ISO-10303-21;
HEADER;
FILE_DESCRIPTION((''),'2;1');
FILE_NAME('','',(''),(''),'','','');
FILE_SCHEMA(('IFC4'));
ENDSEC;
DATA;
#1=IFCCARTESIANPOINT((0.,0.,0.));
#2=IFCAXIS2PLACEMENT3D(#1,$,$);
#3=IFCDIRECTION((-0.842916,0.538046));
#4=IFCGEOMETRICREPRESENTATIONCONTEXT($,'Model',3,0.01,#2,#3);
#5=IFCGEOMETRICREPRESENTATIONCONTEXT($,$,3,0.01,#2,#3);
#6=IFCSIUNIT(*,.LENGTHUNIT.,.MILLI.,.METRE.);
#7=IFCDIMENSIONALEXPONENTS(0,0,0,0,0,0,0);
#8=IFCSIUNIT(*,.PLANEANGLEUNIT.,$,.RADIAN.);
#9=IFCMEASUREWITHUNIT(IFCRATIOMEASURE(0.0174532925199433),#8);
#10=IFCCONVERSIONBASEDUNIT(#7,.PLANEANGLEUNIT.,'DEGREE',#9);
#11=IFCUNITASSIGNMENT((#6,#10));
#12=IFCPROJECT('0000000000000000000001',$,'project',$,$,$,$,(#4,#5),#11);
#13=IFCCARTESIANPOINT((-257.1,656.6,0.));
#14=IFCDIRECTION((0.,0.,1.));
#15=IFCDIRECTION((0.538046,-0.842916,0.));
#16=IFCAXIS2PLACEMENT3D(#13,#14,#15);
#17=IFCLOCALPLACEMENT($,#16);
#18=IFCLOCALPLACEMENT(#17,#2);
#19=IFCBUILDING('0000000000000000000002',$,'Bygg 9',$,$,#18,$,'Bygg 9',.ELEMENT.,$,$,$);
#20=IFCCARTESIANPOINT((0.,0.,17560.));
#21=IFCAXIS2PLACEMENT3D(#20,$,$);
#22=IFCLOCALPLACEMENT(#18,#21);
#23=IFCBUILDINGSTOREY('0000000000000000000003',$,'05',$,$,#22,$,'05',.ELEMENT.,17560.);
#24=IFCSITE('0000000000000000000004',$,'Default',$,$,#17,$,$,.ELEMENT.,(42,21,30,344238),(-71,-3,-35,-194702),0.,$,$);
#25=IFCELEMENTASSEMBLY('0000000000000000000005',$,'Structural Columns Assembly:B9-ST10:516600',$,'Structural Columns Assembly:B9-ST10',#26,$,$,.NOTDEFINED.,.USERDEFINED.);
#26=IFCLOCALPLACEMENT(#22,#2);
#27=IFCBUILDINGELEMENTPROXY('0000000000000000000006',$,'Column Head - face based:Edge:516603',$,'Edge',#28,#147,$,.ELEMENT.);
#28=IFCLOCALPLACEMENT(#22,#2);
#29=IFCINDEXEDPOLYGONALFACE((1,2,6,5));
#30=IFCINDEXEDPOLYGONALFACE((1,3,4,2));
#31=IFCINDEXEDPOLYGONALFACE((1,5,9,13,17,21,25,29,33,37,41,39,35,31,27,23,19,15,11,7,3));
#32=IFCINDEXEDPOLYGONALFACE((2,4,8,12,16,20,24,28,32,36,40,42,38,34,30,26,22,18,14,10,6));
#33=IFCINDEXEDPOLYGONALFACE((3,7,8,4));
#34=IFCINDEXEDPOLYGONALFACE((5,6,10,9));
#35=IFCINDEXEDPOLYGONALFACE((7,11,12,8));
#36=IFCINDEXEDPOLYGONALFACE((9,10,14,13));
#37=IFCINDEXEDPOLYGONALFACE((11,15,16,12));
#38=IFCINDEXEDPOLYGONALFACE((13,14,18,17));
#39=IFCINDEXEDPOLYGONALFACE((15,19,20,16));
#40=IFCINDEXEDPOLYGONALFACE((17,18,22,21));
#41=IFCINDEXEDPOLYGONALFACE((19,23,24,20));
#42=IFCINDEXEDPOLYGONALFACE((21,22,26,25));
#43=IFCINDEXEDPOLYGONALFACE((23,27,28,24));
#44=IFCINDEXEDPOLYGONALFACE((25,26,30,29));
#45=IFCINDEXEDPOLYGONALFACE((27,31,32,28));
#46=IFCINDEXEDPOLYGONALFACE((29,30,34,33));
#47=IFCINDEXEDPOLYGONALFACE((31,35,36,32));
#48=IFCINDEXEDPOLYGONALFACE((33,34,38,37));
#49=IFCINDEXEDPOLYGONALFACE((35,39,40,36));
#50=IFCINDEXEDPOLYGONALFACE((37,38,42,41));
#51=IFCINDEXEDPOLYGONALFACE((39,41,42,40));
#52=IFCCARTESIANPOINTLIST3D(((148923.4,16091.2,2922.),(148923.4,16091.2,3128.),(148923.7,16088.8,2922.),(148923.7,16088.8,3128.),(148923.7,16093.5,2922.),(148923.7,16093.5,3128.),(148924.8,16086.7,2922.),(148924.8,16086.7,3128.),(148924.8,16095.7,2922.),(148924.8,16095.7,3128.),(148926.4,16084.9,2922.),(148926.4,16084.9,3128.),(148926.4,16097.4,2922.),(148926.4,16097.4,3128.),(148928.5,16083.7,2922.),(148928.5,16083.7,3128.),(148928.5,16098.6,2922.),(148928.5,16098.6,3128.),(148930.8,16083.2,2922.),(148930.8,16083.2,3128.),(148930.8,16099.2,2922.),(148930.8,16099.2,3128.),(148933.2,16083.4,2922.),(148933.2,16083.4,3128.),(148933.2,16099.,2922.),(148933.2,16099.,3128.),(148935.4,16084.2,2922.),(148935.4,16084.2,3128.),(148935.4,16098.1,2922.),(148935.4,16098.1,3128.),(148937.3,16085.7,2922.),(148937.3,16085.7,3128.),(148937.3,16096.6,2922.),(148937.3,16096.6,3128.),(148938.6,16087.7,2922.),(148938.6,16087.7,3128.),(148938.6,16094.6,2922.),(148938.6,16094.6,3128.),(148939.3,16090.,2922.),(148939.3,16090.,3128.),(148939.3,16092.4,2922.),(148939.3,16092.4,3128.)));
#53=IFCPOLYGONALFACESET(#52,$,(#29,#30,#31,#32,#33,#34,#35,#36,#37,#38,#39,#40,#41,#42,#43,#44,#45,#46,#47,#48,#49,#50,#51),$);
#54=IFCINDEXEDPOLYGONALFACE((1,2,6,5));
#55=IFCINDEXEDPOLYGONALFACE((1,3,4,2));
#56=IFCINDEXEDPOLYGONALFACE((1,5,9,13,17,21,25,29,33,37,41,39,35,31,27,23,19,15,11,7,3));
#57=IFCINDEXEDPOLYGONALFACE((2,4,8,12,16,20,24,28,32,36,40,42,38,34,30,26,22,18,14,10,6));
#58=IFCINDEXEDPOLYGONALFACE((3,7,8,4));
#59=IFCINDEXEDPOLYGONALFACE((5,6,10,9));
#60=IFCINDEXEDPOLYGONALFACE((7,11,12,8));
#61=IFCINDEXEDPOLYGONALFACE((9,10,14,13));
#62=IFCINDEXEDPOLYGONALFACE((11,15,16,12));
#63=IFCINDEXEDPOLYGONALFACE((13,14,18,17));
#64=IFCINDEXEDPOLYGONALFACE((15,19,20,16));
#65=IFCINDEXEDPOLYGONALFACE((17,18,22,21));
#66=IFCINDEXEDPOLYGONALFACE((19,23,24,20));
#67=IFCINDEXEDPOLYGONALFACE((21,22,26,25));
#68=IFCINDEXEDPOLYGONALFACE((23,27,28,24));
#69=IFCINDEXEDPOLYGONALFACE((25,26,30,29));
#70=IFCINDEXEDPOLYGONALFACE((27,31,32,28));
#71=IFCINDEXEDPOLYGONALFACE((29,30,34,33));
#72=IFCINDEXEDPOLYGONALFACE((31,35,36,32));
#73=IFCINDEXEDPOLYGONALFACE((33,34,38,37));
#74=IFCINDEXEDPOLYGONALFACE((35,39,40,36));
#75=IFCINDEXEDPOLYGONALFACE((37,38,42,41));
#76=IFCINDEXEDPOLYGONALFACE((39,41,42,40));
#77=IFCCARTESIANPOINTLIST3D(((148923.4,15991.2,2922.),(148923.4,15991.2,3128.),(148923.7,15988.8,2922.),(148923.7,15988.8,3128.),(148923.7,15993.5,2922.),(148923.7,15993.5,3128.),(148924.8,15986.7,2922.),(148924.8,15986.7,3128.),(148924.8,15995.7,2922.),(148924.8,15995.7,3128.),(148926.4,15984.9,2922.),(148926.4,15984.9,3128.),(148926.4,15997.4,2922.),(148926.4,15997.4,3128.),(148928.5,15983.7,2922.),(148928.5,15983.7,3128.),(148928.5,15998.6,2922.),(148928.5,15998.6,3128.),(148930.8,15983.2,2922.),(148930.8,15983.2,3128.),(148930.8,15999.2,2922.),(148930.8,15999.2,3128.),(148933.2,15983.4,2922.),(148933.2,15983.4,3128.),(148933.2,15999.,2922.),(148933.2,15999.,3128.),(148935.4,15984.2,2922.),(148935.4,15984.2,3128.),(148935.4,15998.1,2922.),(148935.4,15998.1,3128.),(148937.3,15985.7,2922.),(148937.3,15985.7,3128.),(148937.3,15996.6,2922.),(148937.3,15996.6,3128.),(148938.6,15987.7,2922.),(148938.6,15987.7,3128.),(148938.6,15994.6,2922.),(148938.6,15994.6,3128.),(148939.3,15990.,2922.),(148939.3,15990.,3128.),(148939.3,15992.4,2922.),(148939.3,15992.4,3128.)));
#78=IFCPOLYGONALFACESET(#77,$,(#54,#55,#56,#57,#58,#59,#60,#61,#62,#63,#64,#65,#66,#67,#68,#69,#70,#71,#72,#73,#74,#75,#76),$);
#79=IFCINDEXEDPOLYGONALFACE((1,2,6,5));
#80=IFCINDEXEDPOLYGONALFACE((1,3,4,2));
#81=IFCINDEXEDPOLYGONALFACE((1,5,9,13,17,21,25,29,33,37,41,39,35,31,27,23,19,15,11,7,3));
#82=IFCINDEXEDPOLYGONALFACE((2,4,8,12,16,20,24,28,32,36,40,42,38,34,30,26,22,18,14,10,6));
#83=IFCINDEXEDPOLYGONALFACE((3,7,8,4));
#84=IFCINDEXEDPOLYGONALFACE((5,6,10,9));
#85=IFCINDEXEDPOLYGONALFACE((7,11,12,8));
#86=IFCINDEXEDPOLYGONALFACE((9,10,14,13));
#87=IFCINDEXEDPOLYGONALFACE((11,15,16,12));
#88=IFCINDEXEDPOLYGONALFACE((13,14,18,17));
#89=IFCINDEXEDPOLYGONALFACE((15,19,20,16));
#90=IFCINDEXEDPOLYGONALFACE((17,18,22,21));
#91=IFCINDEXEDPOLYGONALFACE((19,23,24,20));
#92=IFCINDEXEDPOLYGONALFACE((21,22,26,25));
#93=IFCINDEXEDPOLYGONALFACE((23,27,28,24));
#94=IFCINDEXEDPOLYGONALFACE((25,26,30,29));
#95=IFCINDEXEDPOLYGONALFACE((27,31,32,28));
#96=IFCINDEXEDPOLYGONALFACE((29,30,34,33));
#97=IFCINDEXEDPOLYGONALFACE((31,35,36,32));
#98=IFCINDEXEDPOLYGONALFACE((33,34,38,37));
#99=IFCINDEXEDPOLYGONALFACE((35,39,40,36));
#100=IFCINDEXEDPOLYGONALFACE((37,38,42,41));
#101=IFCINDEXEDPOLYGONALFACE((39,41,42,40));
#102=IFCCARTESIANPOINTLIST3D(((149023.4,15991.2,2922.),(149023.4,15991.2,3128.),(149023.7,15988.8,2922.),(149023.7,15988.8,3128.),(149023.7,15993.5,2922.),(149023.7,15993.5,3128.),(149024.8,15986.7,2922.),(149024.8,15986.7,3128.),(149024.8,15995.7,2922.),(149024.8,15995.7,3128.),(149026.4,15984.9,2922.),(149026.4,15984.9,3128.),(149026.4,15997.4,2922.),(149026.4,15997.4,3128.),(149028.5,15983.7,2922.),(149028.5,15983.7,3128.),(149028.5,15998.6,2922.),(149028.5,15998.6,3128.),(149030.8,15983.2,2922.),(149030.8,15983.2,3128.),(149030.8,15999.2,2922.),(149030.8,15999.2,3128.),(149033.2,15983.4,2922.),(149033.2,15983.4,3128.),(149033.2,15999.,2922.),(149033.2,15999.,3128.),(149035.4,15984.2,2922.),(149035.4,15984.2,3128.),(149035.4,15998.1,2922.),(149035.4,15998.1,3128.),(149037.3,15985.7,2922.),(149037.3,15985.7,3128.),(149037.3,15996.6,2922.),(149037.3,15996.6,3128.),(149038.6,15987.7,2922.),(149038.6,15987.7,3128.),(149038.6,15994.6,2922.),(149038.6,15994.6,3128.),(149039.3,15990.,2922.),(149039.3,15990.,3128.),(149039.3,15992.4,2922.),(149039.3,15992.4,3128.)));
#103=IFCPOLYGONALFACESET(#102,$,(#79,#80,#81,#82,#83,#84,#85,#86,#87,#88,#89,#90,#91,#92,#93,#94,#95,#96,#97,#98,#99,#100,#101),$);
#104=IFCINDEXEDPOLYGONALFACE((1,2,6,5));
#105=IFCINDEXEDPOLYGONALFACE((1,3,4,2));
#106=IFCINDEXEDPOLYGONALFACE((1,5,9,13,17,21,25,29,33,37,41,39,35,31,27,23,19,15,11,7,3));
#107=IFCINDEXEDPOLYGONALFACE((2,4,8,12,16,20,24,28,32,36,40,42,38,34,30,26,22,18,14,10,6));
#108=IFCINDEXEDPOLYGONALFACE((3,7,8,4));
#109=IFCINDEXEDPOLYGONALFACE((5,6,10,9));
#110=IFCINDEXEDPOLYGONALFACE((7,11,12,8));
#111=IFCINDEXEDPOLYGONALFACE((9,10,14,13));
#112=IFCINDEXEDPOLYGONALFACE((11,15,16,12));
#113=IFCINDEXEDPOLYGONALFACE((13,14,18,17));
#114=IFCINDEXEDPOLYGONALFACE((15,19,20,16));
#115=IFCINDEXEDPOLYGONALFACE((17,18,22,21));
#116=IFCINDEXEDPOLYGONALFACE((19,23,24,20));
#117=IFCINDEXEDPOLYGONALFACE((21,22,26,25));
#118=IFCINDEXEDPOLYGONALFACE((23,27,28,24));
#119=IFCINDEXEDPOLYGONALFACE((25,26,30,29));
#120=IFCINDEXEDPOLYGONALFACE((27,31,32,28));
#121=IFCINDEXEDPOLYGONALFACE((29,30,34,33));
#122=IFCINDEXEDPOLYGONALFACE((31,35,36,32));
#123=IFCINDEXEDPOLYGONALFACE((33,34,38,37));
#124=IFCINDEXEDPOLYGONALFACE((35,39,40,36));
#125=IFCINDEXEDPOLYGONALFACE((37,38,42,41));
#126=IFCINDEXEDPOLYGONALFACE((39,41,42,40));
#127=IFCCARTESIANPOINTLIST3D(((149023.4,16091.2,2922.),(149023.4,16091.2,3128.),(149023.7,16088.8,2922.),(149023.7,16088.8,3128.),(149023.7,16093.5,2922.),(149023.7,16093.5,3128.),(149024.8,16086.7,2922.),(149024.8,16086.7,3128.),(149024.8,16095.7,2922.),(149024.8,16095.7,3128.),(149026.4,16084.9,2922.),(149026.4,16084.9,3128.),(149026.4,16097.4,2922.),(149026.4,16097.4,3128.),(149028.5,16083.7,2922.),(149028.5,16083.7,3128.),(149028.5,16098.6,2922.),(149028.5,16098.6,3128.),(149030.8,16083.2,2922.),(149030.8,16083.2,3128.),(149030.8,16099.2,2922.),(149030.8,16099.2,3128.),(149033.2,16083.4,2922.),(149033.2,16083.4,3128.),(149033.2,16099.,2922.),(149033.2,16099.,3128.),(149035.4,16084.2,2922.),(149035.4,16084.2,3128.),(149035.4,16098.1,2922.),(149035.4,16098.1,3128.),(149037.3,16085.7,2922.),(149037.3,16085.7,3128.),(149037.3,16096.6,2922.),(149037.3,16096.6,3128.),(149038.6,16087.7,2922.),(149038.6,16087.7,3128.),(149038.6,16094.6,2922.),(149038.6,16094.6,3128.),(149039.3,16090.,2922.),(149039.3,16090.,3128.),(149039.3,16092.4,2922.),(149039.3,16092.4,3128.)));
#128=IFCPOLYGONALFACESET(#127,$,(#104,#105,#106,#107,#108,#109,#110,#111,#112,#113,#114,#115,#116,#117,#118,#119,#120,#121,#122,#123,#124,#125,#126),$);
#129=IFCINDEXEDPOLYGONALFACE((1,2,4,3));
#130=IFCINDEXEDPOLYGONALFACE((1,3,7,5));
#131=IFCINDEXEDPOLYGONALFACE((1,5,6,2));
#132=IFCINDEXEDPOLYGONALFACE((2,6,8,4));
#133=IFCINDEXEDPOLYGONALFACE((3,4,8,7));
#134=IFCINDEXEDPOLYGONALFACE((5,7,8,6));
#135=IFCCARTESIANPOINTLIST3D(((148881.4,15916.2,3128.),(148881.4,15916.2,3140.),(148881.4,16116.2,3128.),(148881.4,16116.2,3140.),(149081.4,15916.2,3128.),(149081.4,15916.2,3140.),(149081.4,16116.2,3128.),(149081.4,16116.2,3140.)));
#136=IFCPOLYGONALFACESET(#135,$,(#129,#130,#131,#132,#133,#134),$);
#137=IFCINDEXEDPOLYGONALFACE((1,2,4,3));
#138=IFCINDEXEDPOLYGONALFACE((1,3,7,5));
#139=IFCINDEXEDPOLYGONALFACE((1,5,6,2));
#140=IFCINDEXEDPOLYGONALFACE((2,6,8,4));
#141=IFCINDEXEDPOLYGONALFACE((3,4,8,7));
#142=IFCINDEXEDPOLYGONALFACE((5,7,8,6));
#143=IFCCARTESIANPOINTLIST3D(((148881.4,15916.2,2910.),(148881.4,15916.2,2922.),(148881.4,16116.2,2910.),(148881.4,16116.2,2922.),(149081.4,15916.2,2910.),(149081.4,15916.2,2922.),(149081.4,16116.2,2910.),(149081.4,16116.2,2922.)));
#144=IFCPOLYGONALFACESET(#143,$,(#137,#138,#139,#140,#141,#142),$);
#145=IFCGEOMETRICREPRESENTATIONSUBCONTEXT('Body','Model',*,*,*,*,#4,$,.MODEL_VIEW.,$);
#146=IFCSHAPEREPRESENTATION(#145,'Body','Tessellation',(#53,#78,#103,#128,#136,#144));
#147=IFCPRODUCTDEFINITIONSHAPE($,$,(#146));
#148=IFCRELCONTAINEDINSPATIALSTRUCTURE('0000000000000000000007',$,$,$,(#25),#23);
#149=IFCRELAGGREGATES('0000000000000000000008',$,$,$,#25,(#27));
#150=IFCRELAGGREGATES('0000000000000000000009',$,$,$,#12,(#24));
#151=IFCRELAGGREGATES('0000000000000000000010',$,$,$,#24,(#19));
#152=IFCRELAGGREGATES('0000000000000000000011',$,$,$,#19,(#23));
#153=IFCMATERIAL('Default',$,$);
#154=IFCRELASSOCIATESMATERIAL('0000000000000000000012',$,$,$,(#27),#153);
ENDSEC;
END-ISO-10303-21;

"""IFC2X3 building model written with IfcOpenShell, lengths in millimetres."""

from ifc_helpers import new_model, entity, si_unit, converted_unit, direction, frame, frame_2d, origin, origin_2d_with_axis, place, context, subcontext, project, spatial, rectangle, circle, extrude, source, transform, mapped, material, element, aggregate, save


model = new_model("IFC2X3")

# Units and contexts
model_context = context("Model", 3, precision=0.01, world=origin(), true_north=direction((-0.842916, 0.538046)))
context_of_model = context(None, 3, precision=0.01, world=origin(), true_north=direction((-0.842916, 0.538046)))
body_context = subcontext(model_context, "Body", "Model", "MODEL_VIEW")
ifc_project = project(units=[si_unit("LENGTHUNIT", "METRE", prefix="MILLI"), converted_unit("PLANEANGLEUNIT", "DEGREE", entity("IfcRatioMeasure", 0.0174532925199433), si_unit("PLANEANGLEUNIT", "RADIAN"), dimensions=[0, 0, 0, 0, 0, 0, 0])], contexts=[model_context, context_of_model])

# Site, building, storey
site_placement = place(None, frame((-257.1, 656.6, 0.0), z_axis=(0.0, 0.0, 1.0), x_axis=(0.538046, -0.842916, 0.0)))
site = spatial("IfcSite", under=ifc_project, at=site_placement, Name="Default", CompositionType="ELEMENT", RefLatitude=(42, 21, 30, 344238), RefLongitude=(-71, -3, -35, -194702), RefElevation=0.0)
building_placement = place(site_placement, origin())
building = spatial("IfcBuilding", under=site, at=building_placement, Name="Bygg 9", LongName="Bygg 9", CompositionType="ELEMENT")
storey_placement = place(building_placement, frame((0.0, 0.0, 17560.0)))
storey = spatial("IfcBuildingStorey", under=building, at=storey_placement, Name="05", LongName="05", CompositionType="ELEMENT", Elevation=17560.0)

# Element assembly
assembly_1_placement = place(storey_placement, origin())
assembly_1 = element("IfcElementAssembly", 1, at=assembly_1_placement, inside=storey, Name="Structural Columns Assembly:B9-ST10:516600", ObjectType="Structural Columns Assembly:B9-ST10", AssemblyPlace="NOTDEFINED", PredefinedType="USERDEFINED")

# Building element proxy
ifc_material_1 = material(Name="Default")
shared_shape_1 = source(origin(), body_context, "Body", "SweptSolid", [
    extrude(circle(Radius=8.0, at=frame_2d((0.0, 0.0), x_axis=(1.0, 0.0))), frame((50.0, -75.0, 12.0)), (0.0, 0.0, 1.0), 206.0),
    extrude(circle(Radius=8.0, at=frame_2d((0.0, 0.0), x_axis=(1.0, 0.0))), frame((50.0, 25.0, 12.0)), (0.0, 0.0, 1.0), 206.0),
    extrude(circle(Radius=8.0, at=frame_2d((0.0, 0.0), x_axis=(1.0, 0.0))), frame((-50.0, 25.0, 12.0)), (0.0, 0.0, 1.0), 206.0),
    extrude(circle(Radius=8.0, at=frame_2d((0.0, 0.0), x_axis=(1.0, 0.0))), frame((-50.0, -75.0, 12.0)), (0.0, 0.0, 1.0), 206.0),
    extrude(rectangle(XDim=200.0, YDim=200.0, at=origin_2d_with_axis()), frame((0.0, 0.0, 218.0), z_axis=(0.0, 0.0, 1.0), x_axis=(-1.0, 0.0, 0.0)), (0.0, 0.0, 1.0), 12.0),
    extrude(rectangle(XDim=200.0, YDim=200.0, at=origin_2d_with_axis()), frame((0.0, 0.0, 0.0), z_axis=(0.0, 0.0, 1.0), x_axis=(0.0, 1.0, 0.0)), (0.0, 0.0, 1.0), 12.0),
])
proxy_1_placement = place(assembly_1_placement, frame((148981.4, 16016.2, 2910.0), z_axis=(0.0, 0.0, 1.0), x_axis=(-1.0, 0.0, 0.0)))
proxy_1 = element("IfcBuildingElementProxy", 2, at=proxy_1_placement, material=ifc_material_1, Name="Column Head - face based:Edge:516603", ObjectType="Edge", CompositionType="ELEMENT", context=body_context, shape_type="MappedRepresentation", body=[
    mapped(shared_shape_1, transform((0.0, 0.0, 0.0), scale=1.0)),
])
aggregate(assembly_1, [proxy_1])

save(model, "model.ifc")
